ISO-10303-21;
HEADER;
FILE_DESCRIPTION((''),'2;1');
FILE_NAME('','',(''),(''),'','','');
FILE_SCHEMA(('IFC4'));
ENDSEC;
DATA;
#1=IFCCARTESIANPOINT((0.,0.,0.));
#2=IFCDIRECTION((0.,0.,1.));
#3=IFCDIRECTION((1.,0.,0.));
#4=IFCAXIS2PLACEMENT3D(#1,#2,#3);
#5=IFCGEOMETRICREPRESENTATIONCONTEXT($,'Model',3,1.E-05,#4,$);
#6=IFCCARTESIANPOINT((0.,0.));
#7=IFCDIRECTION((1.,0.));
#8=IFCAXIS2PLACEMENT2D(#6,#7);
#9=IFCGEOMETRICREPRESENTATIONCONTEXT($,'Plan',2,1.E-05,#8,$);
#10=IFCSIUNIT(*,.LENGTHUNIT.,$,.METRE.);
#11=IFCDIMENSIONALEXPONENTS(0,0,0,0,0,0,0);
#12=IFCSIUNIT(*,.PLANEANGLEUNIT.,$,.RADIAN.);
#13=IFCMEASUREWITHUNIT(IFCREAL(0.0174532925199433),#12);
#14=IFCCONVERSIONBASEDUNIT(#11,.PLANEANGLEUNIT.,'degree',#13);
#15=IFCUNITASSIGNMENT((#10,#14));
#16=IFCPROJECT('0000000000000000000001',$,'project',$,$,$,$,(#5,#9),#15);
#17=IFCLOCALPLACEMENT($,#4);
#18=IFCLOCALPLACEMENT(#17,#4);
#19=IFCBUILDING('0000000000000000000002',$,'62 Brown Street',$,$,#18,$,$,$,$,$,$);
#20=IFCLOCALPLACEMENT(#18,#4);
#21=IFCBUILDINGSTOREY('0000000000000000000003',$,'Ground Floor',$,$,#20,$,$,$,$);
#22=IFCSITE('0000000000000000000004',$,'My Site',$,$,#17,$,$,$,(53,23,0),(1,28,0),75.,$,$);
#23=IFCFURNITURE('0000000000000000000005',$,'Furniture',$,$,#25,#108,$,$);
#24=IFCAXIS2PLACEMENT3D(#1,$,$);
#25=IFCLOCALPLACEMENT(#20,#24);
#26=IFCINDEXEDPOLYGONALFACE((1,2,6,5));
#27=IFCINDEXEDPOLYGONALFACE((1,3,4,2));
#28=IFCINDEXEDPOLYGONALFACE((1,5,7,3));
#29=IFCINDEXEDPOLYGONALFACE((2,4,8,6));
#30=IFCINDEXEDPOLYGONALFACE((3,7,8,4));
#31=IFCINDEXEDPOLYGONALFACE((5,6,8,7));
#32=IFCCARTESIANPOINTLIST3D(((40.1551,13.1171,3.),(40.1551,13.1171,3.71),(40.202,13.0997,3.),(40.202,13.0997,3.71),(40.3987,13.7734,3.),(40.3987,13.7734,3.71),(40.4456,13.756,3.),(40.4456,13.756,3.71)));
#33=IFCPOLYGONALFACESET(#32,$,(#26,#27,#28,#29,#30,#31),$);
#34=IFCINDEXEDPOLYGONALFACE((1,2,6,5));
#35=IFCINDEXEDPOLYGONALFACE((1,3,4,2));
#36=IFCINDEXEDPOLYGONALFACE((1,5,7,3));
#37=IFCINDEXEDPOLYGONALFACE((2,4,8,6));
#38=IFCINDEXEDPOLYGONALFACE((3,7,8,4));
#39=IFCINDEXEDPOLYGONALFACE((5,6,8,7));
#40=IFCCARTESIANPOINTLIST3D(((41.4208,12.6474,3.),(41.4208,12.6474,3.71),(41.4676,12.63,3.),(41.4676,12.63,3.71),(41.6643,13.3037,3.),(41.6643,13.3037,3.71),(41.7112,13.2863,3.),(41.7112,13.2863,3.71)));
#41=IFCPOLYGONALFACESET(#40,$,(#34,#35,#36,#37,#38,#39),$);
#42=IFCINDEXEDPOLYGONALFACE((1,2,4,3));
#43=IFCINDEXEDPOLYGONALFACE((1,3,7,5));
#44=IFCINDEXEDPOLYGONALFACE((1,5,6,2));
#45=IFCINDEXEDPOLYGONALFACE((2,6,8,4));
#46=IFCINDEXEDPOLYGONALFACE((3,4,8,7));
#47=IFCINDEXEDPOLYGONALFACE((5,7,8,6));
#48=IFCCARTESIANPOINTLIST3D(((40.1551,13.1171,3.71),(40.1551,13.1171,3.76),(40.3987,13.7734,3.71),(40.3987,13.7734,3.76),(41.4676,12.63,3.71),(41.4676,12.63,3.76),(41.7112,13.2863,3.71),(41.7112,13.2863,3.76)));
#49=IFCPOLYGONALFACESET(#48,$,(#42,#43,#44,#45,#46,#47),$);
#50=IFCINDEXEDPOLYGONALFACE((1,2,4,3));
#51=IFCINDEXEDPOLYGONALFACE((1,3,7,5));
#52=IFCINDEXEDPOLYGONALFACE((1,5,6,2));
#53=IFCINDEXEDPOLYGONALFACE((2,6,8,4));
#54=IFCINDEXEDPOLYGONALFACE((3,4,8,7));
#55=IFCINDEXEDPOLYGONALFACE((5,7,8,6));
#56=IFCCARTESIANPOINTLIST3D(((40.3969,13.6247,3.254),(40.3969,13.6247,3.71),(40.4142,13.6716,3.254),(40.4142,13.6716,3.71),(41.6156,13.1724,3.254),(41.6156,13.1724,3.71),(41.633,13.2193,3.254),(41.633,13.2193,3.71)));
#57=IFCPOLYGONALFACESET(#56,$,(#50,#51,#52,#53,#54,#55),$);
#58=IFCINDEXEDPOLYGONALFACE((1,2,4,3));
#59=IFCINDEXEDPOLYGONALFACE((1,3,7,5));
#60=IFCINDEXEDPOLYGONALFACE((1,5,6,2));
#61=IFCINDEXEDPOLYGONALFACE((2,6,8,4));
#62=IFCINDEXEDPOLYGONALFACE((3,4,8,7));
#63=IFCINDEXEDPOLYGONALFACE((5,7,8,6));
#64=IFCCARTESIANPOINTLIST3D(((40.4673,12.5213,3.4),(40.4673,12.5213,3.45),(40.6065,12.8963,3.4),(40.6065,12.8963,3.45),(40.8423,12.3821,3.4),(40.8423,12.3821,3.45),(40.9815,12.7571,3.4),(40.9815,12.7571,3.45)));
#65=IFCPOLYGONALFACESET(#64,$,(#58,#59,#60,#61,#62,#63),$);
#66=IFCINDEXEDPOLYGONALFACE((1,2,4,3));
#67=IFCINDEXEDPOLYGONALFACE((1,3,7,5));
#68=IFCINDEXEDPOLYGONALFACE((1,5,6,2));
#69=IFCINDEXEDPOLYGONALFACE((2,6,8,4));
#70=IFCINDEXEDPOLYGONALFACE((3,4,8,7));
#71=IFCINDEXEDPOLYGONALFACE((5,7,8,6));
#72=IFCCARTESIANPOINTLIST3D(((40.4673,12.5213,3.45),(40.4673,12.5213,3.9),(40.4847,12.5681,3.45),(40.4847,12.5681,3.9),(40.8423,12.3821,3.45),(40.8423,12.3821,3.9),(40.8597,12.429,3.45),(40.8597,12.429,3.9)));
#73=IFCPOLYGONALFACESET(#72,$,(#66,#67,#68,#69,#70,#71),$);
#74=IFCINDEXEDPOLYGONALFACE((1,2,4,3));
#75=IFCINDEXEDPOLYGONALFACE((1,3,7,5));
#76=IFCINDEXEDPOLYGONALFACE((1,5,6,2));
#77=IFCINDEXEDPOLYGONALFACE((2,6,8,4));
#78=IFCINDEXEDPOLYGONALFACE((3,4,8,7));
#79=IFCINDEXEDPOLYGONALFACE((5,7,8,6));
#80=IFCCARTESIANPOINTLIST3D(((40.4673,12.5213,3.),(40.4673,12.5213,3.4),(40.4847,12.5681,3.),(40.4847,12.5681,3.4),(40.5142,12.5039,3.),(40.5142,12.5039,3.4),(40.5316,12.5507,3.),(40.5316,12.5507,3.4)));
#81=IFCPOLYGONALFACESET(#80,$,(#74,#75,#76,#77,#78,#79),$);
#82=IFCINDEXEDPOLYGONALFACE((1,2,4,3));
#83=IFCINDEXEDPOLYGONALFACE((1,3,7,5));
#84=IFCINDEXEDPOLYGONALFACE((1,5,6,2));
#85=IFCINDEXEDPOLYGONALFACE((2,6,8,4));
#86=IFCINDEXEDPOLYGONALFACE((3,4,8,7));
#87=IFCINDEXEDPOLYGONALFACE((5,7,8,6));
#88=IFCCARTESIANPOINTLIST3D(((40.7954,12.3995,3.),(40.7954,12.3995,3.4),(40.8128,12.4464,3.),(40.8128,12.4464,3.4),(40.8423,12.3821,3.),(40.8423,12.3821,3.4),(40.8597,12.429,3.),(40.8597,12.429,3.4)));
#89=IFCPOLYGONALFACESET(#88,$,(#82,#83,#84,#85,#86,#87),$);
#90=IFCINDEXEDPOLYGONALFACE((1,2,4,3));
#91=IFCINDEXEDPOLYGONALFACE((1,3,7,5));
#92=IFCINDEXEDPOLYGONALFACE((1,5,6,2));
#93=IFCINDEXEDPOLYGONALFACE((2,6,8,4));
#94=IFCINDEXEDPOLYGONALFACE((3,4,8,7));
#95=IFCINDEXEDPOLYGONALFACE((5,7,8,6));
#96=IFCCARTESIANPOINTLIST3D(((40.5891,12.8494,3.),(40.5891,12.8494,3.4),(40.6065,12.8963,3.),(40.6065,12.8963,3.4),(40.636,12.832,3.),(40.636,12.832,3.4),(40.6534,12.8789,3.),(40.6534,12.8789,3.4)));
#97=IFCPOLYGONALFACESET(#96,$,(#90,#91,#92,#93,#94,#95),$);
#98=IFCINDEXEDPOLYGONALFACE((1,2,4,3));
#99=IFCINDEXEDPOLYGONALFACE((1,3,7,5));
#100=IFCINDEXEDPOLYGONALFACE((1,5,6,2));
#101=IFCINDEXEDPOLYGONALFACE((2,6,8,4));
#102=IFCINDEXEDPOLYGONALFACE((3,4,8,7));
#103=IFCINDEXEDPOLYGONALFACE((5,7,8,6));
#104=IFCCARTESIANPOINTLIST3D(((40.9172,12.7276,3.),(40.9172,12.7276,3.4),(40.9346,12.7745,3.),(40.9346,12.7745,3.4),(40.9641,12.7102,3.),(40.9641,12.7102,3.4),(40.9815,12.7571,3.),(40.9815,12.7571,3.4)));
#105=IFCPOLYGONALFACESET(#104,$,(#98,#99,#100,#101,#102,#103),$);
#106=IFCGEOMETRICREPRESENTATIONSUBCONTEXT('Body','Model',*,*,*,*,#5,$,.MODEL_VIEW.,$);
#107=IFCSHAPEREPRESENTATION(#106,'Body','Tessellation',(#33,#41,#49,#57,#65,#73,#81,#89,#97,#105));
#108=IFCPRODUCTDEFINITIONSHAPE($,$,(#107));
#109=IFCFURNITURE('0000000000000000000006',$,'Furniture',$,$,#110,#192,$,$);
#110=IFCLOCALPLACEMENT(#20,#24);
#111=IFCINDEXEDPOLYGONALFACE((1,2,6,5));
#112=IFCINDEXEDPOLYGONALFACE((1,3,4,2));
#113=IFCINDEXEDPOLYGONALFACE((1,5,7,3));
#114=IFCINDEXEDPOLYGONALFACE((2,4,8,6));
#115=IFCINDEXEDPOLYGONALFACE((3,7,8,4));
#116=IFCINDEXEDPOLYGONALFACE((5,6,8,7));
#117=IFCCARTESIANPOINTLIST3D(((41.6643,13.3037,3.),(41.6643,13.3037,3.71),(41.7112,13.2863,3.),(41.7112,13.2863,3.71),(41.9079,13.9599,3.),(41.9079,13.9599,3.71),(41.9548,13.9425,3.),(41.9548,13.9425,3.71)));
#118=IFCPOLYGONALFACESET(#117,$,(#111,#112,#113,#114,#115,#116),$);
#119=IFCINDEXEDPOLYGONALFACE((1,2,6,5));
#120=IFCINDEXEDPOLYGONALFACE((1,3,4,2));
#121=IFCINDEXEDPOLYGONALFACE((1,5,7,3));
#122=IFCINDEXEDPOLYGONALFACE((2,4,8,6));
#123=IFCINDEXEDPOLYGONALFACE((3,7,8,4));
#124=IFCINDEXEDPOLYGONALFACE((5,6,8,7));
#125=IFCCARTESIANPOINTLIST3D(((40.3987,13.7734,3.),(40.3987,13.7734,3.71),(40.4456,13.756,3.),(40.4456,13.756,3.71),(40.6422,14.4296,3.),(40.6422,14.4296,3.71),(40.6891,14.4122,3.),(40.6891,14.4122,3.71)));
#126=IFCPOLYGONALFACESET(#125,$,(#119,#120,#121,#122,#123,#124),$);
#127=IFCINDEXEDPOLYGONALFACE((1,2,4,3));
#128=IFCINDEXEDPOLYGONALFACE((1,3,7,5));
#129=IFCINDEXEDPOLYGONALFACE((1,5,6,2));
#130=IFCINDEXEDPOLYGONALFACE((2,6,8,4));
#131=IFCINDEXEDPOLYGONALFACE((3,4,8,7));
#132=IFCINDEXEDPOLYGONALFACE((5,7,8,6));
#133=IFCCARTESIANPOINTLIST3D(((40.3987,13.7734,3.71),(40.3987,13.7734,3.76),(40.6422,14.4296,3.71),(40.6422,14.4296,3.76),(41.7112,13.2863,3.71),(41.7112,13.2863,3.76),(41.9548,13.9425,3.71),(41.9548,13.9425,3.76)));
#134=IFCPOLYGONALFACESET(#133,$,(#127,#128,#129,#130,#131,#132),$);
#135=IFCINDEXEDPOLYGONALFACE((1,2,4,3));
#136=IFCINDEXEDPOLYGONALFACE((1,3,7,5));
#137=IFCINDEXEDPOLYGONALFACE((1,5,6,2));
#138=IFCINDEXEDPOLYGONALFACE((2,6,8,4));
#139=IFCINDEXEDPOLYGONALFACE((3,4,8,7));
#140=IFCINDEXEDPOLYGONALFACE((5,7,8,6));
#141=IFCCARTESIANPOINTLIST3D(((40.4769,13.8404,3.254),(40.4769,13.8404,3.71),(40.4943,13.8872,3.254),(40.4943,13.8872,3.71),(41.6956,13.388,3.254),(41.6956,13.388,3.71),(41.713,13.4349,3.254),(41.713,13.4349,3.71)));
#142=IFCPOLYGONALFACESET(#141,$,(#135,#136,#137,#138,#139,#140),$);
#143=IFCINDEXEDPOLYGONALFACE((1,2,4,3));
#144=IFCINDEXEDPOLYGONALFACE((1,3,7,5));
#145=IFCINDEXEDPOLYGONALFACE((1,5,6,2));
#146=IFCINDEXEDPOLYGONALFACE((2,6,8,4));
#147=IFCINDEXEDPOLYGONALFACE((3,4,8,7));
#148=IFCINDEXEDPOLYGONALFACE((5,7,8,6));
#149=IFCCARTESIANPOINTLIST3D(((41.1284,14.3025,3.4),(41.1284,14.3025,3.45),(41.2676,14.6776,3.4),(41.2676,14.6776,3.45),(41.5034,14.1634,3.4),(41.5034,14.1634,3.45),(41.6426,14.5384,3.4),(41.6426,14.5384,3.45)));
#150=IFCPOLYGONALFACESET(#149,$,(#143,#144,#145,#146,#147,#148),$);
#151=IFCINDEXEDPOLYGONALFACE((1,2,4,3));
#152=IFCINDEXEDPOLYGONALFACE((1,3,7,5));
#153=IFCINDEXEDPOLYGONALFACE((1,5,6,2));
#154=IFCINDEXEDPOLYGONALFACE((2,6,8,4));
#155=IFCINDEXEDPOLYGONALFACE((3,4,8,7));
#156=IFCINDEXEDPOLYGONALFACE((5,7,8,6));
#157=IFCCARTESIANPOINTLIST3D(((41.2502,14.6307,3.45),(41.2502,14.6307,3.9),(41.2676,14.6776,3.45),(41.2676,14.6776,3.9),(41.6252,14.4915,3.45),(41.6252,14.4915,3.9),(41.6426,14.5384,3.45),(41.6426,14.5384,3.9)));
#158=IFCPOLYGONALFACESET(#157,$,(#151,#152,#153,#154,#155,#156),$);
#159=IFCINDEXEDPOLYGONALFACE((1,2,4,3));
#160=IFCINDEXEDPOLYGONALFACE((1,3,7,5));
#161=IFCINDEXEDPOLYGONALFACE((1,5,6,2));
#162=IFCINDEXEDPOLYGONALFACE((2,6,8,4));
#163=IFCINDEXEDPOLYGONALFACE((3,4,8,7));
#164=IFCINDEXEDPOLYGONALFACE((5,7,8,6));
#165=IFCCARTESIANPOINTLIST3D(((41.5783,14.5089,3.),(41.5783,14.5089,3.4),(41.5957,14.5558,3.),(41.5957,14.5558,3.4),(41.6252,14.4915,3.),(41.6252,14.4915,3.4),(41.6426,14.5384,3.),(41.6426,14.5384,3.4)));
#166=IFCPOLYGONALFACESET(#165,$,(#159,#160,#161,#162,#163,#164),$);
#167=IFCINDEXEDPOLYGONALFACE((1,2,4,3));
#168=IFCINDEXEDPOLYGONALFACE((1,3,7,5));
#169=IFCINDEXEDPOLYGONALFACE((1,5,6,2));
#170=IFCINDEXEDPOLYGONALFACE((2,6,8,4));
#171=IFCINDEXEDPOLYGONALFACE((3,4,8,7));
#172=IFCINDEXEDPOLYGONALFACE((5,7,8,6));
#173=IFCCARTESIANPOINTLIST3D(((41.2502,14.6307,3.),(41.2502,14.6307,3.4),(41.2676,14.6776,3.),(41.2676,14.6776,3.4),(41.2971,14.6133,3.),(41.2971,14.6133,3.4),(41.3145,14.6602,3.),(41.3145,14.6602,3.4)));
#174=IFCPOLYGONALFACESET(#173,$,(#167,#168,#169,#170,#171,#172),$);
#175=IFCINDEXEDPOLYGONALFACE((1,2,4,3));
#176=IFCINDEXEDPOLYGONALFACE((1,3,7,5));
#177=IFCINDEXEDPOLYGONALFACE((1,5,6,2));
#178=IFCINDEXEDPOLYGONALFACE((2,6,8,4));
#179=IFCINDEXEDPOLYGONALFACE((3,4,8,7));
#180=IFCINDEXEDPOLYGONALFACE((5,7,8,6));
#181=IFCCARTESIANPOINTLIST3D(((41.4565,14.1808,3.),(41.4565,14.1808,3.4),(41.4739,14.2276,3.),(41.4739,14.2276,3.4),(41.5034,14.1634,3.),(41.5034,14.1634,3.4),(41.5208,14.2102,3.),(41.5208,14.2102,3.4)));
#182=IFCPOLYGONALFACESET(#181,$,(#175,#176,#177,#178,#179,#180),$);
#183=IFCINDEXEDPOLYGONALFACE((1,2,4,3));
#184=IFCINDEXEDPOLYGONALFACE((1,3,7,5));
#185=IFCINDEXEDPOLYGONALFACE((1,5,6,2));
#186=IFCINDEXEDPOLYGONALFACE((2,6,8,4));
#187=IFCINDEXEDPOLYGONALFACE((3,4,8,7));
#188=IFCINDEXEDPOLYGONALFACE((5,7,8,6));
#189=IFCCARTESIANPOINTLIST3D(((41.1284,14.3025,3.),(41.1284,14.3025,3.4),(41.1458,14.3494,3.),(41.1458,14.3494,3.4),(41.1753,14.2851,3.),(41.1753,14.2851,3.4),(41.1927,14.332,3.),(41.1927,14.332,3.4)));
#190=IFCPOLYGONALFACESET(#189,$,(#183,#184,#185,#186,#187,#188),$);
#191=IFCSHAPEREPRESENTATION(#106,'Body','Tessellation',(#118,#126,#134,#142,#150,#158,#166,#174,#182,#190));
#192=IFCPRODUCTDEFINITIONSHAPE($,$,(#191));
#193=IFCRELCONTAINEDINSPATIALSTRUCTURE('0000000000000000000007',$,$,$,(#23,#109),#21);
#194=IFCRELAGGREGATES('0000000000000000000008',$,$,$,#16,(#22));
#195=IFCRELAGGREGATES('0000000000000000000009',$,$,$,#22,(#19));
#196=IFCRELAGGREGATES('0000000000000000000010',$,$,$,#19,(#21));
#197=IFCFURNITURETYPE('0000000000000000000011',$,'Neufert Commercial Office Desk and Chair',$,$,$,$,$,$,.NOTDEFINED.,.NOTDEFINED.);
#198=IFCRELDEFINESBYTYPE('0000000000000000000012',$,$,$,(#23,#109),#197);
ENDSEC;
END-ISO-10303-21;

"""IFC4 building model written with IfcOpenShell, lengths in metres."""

from ifc_helpers import new_model, entity, si_unit, converted_unit, frame, origin_with_axes, origin_2d_with_axis, place, context, subcontext, project, spatial, line, indexed_curve, outline, extrude, shape, source, transform, mapped, type_object, type_shapes, element, save


model = new_model("IFC4")

# Units and contexts
model_context = context("Model", 3, precision=1e-05, world=origin_with_axes())
plan_context = context("Plan", 2, precision=1e-05, world=origin_2d_with_axis())
body_context_1 = subcontext(model_context, "Body", "Model", "MODEL_VIEW")
body_context_2 = subcontext(plan_context, "Body", "Plan", "PLAN_VIEW")
ifc_project = project(units=[si_unit("LENGTHUNIT", "METRE"), converted_unit("PLANEANGLEUNIT", "degree", entity("IfcReal", 0.0174532925199433), si_unit("PLANEANGLEUNIT", "RADIAN"), dimensions=[0, 0, 0, 0, 0, 0, 0])], contexts=[model_context, plan_context])

# Site, building, storey
site_placement = place(None, origin_with_axes())
site = spatial("IfcSite", under=ifc_project, at=site_placement, Name="My Site", RefLatitude=(53, 23, 0), RefLongitude=(1, 28, 0), RefElevation=75.0)
building_placement = place(site_placement, origin_with_axes())
building = spatial("IfcBuilding", under=site, at=building_placement, Name="62 Brown Street")
storey_placement = place(building_placement, origin_with_axes())
storey = spatial("IfcBuildingStorey", under=building, at=storey_placement, Name="Ground Floor")

# Furniture
furniture_type = type_object("IfcFurnitureType", Name="Neufert Commercial Office Desk and Chair", AssemblyPlace="NOTDEFINED", PredefinedType="NOTDEFINED")
shared_shape_1 = source(origin_with_axes(), body_context_1, "Body", "SweptSolid", [
    extrude(outline(indexed_curve([(0.0, 0.0), (0.05, 0.0), (0.05, 0.7), (0.0, 0.7)], segments=[line(1, 2, 3, 4, 1)])), frame((0.0, 0.45, 0.0), z_axis=(0.0, 0.0, 1.0), x_axis=(1.0, 0.0, 0.0)), (0.0, 0.0, 1.0), 0.71),
    extrude(outline(indexed_curve([(0.0, 0.0), (0.05, 0.0), (0.05, 0.7), (0.0, 0.7)], segments=[line(1, 2, 3, 4, 1)])), frame((1.35, 0.45, 0.0), z_axis=(0.0, 0.0, 1.0), x_axis=(1.0, 0.0, 0.0)), (0.0, 0.0, 1.0), 0.71),
    extrude(outline(indexed_curve([(0.0, 0.0), (1.4, 0.0), (1.4, 0.7), (0.0, 0.7)], segments=[line(1, 2, 3, 4, 1)])), frame((0.0, 0.45, 0.71), z_axis=(0.0, 0.0, 1.0), x_axis=(1.0, 0.0, 0.0)), (0.0, 0.0, 1.0), 0.05),
    extrude(outline(indexed_curve([(0.05, 0.56), (1.35, 0.56), (1.35, 0.61), (0.05, 0.61)], segments=[line(1, 2, 3, 4, 1)])), frame((0.0, 0.45, 0.254), z_axis=(0.0, 0.0, 1.0), x_axis=(1.0, 0.0, 0.0)), (0.0, 0.0, 1.0), 0.456),
    extrude(outline(indexed_curve([(-0.2, 0.0), (0.2, 0.0), (0.2, 0.4), (-0.2, 0.4)], segments=[line(1, 2, 3, 4, 1)])), frame((0.7, 0.0, 0.45), z_axis=(0.0, 0.0, 1.0), x_axis=(1.0, 0.0, 0.0)), (0.0, 0.0, -1.0), 0.05),
    extrude(outline(indexed_curve([(-0.2, 0.0), (0.2, 0.0), (0.2, 0.05), (-0.2, 0.05)], segments=[line(1, 2, 3, 4, 1)])), frame((0.7, 0.0, 0.9), z_axis=(0.0, 0.0, 1.0), x_axis=(1.0, 0.0, 0.0)), (0.0, 0.0, -1.0), 0.45),
    extrude(outline(indexed_curve([(-0.2, 0.0), (-0.15, 0.0), (-0.15, 0.05), (-0.2, 0.05)], segments=[line(1, 2, 3, 4, 1)])), frame((0.7, 0.0, 0.0), z_axis=(0.0, 0.0, 1.0), x_axis=(1.0, 0.0, 0.0)), (0.0, 0.0, 1.0), 0.4),
    extrude(outline(indexed_curve([(0.2, 0.0), (0.15, 0.0), (0.15, 0.05), (0.2, 0.05)], segments=[line(1, 2, 3, 4, 1)])), frame((0.7, 0.0, 0.0), z_axis=(0.0, 0.0, 1.0), x_axis=(1.0, 0.0, 0.0)), (0.0, 0.0, 1.0), 0.4),
    extrude(outline(indexed_curve([(-0.2, 0.4), (-0.15, 0.4), (-0.15, 0.35), (-0.2, 0.35)], segments=[line(1, 2, 3, 4, 1)])), frame((0.7, 0.0, 0.0), z_axis=(0.0, 0.0, 1.0), x_axis=(1.0, 0.0, 0.0)), (0.0, 0.0, 1.0), 0.4),
    extrude(outline(indexed_curve([(0.2, 0.4), (0.15, 0.4), (0.15, 0.35), (0.2, 0.35)], segments=[line(1, 2, 3, 4, 1)])), frame((0.7, 0.0, 0.0), z_axis=(0.0, 0.0, 1.0), x_axis=(1.0, 0.0, 0.0)), (0.0, 0.0, 1.0), 0.4),
])
shared_shape_2 = source(origin_with_axes(), body_context_2, "Body", "Curve2D", [
    entity("IfcIndexedPolyCurve", entity("IfcCartesianPointList2D", [[0.0, 0.45], [1.4, 0.45], [1.4, 1.15], [0.0, 1.15]]), [entity("IfcLineIndex", [1, 2, 3, 4, 1])]),
    entity("IfcIndexedPolyCurve", entity("IfcCartesianPointList2D", [[0.5, 0.4], [0.9, 0.4]])),
    entity("IfcIndexedPolyCurve", entity("IfcCartesianPointList2D", [[0.5, 0.4], [0.5, 0.2], [0.5586, 0.0586], [0.7, 0.0], [0.8414, 0.0586], [0.9, 0.2], [0.9, 0.4]]), [entity("IfcLineIndex", [1, 2]), entity("IfcArcIndex", [2, 3, 4]), entity("IfcArcIndex", [4, 5, 6]), entity("IfcLineIndex", [6, 7])]),
    entity("IfcIndexedPolyCurve", entity("IfcCartesianPointList2D", [[0.54, 0.4], [0.54, 0.2], [0.5869, 0.0869], [0.7, 0.04], [0.8131, 0.0869], [0.86, 0.2], [0.86, 0.4]]), [entity("IfcLineIndex", [1, 2]), entity("IfcArcIndex", [2, 3, 4]), entity("IfcArcIndex", [4, 5, 6]), entity("IfcLineIndex", [6, 7])]),
])
type_shapes(furniture_type, [shared_shape_1, shared_shape_2])
for number, where, z_axis, x_axis, name in (
    (1, (39.9986, 12.6952, 3.0), (0.0, 0.0, 1.0), (0.937515, -0.347944, 0.0), "Furniture"),
    (2, (42.1113, 14.3644, 3.0), (0.0, 0.0, 1.0), (-0.937515, 0.347945, 0.0), "Furniture"),
):
    element("IfcFurniture", number, at=place(storey_placement, frame(where, z_axis=z_axis, x_axis=x_axis)), inside=storey, type_object=furniture_type, Name=name, shapes=[
        shape(body_context_1, "Body", "MappedRepresentation", [mapped(shared_shape_1, transform((0.0, 0.0, 0.0), x_axis=(1.0, 0.0, 0.0), y_axis=(0.0, 1.0, 0.0), z_axis=(0.0, 0.0, 1.0), scale=1.0))]),
        shape(body_context_2, "Body", "MappedRepresentation", [mapped(shared_shape_2, transform((0.0, 0.0, 0.0), x_axis=(1.0, 0.0, 0.0), y_axis=(0.0, 1.0, 0.0), z_axis=(0.0, 0.0, 1.0), scale=1.0))]),
    ])

save(model, "model.ifc")
